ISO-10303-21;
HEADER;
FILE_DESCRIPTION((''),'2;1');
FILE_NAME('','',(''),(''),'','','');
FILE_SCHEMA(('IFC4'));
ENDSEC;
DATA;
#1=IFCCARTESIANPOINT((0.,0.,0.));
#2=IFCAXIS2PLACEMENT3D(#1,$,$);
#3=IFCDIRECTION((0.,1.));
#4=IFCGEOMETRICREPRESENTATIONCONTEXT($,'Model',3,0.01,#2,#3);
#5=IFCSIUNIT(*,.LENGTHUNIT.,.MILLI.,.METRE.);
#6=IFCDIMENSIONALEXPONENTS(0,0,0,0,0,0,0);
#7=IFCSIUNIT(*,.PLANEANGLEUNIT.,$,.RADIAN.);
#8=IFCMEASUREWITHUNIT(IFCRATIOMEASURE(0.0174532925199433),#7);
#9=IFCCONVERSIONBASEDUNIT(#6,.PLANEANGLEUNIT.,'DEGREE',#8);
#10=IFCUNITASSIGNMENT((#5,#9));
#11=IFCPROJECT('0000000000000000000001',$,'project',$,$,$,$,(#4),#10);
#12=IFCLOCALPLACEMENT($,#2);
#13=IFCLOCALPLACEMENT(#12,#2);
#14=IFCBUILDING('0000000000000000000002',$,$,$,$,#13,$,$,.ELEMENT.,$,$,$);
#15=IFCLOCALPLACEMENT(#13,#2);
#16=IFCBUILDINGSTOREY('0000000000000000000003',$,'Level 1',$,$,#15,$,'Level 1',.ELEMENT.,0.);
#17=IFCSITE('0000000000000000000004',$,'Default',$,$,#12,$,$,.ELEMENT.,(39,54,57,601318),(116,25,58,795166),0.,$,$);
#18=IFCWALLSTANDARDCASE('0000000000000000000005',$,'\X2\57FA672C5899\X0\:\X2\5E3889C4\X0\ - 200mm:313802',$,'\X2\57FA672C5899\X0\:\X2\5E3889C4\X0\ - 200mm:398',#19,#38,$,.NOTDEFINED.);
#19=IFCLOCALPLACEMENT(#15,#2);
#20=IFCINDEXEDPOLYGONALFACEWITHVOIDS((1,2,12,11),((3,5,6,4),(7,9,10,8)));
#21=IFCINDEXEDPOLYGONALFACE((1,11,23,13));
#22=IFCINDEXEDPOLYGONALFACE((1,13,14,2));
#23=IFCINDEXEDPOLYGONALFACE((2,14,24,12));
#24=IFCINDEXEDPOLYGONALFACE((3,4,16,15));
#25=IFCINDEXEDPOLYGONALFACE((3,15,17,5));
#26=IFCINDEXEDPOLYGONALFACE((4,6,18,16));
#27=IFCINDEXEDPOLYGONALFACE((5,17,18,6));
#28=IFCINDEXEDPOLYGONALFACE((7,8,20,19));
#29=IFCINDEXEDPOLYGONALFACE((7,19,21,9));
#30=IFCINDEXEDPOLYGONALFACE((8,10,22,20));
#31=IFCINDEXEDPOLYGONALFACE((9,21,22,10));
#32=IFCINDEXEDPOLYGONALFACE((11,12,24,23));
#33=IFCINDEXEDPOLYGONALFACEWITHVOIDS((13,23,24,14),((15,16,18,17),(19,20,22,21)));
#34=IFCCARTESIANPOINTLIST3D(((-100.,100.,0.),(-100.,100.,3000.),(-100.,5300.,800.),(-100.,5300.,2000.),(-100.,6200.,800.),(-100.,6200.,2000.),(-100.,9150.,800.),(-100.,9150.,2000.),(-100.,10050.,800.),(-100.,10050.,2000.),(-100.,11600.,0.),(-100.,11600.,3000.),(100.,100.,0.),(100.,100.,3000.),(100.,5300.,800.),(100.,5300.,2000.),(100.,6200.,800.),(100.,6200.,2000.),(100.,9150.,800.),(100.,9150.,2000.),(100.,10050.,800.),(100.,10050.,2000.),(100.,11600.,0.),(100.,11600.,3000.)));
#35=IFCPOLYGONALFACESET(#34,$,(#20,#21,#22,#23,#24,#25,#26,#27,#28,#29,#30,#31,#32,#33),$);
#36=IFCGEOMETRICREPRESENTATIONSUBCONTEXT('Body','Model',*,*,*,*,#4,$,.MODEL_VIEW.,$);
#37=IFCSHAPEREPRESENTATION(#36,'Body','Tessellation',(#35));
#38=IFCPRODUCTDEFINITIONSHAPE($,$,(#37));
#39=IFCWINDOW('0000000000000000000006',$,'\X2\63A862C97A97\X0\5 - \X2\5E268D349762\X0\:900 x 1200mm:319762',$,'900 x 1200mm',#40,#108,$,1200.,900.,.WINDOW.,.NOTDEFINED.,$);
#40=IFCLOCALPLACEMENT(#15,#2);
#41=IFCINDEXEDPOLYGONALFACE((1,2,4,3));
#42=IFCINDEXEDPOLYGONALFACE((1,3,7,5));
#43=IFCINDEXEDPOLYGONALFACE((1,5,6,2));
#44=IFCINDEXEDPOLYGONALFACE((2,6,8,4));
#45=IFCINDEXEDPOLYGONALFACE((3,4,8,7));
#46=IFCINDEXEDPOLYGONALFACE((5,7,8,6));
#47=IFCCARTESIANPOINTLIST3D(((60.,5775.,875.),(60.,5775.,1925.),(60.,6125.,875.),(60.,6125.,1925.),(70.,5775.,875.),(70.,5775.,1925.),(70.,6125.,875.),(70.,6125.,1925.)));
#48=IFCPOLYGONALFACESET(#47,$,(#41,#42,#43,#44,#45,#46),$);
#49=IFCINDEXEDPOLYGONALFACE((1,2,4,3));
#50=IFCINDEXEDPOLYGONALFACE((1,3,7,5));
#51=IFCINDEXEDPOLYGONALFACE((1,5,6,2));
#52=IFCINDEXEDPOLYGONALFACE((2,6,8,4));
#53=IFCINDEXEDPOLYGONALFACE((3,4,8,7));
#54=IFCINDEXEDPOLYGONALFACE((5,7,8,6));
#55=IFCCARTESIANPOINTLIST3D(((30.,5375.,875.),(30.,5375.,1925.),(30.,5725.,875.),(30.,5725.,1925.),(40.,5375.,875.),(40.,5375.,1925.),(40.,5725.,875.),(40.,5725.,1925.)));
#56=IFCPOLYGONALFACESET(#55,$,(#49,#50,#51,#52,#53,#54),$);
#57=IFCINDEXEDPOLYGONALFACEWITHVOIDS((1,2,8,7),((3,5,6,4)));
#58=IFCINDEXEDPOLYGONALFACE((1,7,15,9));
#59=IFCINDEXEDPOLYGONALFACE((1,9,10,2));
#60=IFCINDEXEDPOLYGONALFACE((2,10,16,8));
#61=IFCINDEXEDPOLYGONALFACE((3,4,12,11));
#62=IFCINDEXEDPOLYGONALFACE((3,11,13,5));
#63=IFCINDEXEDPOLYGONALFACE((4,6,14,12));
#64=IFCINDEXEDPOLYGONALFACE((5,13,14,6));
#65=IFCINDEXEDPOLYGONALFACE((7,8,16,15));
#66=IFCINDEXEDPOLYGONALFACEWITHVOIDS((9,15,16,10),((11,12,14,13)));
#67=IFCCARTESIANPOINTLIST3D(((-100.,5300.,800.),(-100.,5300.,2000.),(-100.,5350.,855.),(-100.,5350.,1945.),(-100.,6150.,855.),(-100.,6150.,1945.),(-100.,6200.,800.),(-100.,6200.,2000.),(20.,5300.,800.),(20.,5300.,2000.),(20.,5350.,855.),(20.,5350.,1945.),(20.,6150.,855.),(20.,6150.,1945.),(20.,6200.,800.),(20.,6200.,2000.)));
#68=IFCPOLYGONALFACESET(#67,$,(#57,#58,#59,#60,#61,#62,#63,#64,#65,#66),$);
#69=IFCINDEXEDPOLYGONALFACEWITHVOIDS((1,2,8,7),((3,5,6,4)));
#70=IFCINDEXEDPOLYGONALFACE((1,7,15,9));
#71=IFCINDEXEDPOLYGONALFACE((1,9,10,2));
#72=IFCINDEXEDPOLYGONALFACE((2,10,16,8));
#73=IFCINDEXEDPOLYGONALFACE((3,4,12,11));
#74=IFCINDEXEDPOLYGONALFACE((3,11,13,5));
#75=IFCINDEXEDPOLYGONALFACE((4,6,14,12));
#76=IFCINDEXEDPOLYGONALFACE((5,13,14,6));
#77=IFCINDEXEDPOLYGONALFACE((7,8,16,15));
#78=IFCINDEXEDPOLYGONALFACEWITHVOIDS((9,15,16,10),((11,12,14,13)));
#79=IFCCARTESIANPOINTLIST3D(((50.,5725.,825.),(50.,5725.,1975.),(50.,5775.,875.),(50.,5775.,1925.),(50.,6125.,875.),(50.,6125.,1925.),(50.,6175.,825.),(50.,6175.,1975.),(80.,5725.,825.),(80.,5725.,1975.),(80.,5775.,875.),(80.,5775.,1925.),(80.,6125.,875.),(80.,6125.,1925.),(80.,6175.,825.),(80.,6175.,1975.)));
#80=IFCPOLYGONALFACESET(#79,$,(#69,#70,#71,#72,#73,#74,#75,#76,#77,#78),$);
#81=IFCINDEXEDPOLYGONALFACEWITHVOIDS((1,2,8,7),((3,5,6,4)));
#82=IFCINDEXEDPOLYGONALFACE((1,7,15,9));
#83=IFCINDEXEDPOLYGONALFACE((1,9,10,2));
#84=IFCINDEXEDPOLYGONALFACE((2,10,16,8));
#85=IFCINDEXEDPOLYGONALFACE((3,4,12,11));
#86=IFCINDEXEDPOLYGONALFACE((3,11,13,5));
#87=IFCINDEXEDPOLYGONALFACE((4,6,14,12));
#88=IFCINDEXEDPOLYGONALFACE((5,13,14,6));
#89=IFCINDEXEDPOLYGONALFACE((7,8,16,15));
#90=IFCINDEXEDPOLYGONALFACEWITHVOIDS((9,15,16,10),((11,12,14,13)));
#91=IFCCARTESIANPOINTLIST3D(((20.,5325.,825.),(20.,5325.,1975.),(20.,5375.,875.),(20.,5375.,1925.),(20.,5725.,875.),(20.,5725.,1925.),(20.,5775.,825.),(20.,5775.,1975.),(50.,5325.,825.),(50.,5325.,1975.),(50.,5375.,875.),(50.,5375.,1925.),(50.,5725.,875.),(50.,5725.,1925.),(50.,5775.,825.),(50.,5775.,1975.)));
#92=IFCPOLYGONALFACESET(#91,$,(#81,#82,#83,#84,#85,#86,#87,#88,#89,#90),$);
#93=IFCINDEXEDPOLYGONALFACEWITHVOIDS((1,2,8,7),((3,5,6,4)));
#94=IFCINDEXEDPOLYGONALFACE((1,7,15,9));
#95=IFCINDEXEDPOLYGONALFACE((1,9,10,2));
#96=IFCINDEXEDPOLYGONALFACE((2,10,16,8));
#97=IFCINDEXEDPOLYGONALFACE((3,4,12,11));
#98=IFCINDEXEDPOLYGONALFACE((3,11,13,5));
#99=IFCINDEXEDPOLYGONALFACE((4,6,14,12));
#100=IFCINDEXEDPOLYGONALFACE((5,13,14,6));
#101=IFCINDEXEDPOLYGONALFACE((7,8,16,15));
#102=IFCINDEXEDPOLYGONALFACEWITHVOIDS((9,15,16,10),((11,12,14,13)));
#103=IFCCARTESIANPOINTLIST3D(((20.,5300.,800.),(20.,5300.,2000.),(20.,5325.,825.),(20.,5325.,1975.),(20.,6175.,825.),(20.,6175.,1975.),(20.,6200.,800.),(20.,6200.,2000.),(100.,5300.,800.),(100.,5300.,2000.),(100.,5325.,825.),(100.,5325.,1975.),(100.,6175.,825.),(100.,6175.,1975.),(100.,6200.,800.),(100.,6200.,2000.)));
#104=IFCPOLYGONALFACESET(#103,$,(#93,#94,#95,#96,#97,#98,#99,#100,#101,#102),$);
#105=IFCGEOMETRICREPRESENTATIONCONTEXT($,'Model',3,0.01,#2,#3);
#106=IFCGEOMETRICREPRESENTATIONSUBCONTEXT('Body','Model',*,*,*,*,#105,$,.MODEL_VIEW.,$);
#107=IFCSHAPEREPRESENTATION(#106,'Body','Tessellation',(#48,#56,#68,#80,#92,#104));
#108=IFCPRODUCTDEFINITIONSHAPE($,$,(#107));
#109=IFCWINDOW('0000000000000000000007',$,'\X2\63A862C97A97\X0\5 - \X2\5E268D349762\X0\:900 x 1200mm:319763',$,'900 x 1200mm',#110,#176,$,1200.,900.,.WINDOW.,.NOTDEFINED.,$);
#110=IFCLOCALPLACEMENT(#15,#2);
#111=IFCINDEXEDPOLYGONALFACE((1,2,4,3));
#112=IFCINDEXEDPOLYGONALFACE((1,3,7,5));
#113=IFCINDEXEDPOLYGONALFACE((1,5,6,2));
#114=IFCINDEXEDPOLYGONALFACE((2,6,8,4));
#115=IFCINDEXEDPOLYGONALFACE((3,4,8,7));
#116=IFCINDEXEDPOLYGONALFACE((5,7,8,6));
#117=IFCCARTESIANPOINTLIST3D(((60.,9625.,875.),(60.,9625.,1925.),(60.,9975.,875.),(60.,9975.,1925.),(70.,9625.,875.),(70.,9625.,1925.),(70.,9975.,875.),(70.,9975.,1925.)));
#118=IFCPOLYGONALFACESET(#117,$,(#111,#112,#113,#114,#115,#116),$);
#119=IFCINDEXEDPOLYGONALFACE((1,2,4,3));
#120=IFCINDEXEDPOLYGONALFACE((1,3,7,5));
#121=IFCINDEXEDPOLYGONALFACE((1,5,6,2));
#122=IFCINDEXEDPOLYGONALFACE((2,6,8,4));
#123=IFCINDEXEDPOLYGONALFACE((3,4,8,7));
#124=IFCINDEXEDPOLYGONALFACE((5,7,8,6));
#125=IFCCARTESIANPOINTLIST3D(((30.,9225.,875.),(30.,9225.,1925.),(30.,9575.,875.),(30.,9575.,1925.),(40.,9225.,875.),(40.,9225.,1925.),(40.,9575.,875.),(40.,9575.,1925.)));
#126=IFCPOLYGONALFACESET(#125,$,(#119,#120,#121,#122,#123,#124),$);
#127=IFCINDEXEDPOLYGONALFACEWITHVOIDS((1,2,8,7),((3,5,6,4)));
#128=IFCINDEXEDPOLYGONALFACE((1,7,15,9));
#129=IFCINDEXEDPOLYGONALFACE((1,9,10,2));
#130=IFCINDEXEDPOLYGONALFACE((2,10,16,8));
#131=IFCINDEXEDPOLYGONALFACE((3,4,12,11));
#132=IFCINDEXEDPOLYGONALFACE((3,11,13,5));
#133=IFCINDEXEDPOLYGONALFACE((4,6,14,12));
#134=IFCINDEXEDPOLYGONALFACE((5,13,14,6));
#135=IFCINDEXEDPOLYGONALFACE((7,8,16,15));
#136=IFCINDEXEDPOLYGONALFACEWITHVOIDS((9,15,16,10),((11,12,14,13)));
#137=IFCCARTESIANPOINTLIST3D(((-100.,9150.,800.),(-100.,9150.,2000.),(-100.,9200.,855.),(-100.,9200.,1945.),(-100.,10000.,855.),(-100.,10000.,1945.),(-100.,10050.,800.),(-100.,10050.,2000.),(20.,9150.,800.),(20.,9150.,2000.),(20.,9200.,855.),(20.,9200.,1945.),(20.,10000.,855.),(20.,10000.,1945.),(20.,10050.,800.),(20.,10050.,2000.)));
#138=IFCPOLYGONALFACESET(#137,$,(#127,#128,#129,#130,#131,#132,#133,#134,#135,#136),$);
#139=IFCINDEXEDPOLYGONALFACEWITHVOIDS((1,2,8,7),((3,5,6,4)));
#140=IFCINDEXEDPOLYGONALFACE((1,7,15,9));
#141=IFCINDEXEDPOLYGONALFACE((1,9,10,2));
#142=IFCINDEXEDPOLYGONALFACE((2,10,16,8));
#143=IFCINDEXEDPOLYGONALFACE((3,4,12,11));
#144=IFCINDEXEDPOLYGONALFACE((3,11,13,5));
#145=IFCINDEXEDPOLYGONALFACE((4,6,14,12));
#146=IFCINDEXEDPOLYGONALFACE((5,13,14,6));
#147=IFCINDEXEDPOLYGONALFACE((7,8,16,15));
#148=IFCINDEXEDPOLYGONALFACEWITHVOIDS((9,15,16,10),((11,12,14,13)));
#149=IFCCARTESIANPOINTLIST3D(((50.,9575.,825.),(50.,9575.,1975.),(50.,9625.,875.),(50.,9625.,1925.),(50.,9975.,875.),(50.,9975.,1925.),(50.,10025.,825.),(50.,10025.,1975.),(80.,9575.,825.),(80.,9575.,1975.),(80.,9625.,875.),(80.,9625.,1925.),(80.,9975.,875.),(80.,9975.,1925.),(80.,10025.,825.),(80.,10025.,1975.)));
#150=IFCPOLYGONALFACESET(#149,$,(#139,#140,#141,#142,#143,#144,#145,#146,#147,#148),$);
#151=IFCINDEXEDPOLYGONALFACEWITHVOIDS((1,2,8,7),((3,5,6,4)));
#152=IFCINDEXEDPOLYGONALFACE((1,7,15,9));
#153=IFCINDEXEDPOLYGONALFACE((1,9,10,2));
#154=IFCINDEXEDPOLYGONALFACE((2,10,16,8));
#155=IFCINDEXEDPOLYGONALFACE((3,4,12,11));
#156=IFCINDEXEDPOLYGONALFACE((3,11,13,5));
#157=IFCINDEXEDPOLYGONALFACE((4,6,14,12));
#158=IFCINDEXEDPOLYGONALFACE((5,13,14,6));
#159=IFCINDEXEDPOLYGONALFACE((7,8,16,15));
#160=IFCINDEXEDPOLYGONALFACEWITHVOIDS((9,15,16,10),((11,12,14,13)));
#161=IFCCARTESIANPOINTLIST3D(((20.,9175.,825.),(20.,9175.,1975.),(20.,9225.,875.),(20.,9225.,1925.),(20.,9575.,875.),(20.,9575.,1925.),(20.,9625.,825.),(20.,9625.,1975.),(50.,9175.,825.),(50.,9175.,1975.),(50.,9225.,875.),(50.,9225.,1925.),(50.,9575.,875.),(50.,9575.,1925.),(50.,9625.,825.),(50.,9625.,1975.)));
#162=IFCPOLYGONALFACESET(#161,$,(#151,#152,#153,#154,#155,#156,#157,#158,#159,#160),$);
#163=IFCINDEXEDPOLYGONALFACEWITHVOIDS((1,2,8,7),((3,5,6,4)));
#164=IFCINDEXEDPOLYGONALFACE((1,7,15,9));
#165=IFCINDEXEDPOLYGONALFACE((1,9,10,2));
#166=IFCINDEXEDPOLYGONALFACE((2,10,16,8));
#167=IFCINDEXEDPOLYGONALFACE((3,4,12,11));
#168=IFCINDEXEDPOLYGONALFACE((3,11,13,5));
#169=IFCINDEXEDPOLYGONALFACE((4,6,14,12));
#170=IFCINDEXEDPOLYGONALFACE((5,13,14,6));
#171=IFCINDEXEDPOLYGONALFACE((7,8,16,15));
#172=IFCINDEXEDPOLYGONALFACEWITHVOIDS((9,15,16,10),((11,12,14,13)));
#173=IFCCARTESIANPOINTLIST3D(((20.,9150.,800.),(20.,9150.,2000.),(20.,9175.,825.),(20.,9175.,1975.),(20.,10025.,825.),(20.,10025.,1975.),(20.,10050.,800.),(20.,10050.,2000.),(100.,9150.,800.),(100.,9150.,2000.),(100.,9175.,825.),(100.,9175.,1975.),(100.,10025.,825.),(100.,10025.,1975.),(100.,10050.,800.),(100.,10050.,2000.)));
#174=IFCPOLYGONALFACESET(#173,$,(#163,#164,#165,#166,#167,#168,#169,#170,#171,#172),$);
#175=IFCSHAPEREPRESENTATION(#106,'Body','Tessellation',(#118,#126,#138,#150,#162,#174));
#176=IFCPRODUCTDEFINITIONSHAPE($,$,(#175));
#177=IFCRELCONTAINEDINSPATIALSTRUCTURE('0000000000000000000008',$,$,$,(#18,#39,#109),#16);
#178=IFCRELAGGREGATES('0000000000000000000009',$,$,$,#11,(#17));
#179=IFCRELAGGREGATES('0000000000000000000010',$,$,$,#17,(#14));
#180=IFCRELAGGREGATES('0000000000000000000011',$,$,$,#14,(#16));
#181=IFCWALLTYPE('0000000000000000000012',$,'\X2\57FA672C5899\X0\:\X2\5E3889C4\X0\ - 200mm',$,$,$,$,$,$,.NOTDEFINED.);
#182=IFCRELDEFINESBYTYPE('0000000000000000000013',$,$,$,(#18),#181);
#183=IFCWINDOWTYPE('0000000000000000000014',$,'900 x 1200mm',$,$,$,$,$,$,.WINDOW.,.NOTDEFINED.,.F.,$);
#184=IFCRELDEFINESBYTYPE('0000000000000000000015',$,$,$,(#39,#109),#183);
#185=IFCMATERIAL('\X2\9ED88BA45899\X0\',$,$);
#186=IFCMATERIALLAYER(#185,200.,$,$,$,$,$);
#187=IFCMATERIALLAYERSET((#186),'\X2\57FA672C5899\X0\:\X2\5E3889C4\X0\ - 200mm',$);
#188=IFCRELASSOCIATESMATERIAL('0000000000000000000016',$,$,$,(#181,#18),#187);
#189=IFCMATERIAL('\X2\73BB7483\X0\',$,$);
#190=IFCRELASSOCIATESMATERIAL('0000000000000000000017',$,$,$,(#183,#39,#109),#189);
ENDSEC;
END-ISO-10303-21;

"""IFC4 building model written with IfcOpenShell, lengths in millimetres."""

from ifc_helpers import new_model, entity, si_unit, converted_unit, direction, frame, frame_2d, origin, origin_2d_with_axis, place, context, subcontext, project, spatial, polyline, rectangle, outline, extrude, source, transform, mapped, material, layer, layer_set, layer_usage, type_object, type_shapes, element, fill, save


model = new_model("IFC4")

# Units and contexts
model_context_1 = context("Model", 3, precision=0.01, world=origin(), true_north=direction((0.0, 1.0)))
model_context_2 = context("Model", 3, precision=0.01, world=origin(), true_north=direction((0.0, 1.0)))
body_context_1 = subcontext(model_context_1, "Body", "Model", "MODEL_VIEW")
body_context_2 = subcontext(model_context_2, "Body", "Model", "MODEL_VIEW")
ifc_project = project(units=[si_unit("LENGTHUNIT", "METRE", prefix="MILLI"), converted_unit("PLANEANGLEUNIT", "DEGREE", entity("IfcRatioMeasure", 0.0174532925199433), si_unit("PLANEANGLEUNIT", "RADIAN"), dimensions=[0, 0, 0, 0, 0, 0, 0])], contexts=[model_context_1])

# Site, building, storey
site_placement = place(None, origin())
site = spatial("IfcSite", under=ifc_project, at=site_placement, Name="Default", CompositionType="ELEMENT", RefLatitude=(39, 54, 57, 601318), RefLongitude=(116, 25, 58, 795166), RefElevation=0.0)
building_placement = place(site_placement, origin())
building = spatial("IfcBuilding", under=site, at=building_placement, CompositionType="ELEMENT")
storey_placement = place(building_placement, origin())
storey = spatial("IfcBuildingStorey", under=building, at=storey_placement, Name="Level 1", LongName="Level 1", CompositionType="ELEMENT", Elevation=0.0)

# Wall, openings, windows
ifc_material_1 = material(Name="默认墙")
ifc_layer_1 = layer(ifc_material_1, 200.0)
ifc_layer_set_1 = layer_set([ifc_layer_1], Name="基本墙:常规 - 200mm")
ifc_layer_usage_1 = layer_usage(ifc_layer_set_1, "AXIS2", "NEGATIVE", 100.0)
wall_type_1 = type_object("IfcWallType", Name="基本墙:常规 - 200mm", PredefinedType="NOTDEFINED", material=ifc_layer_set_1)
wall_1_placement = place(storey_placement, frame((0.0, 100.0, 0.0), z_axis=(0.0, 0.0, 1.0), x_axis=(0.0, 1.0, 0.0)))
wall_1 = element("IfcWallStandardCase", 1, at=wall_1_placement, inside=storey, type_object=wall_type_1, material=ifc_layer_usage_1, Name="基本墙:常规 - 200mm:313802", ObjectType="基本墙:常规 - 200mm:398", PredefinedType="NOTDEFINED", context=body_context_1, shape_type="SweptSolid", body=[
    extrude(rectangle(XDim=11500.0, YDim=200.0, at=frame_2d((5750.0, 0.0), x_axis=(-1.0, 0.0))), origin(), (0.0, 0.0, 1.0), 3000.0),
])
placement_1 = place(None, origin())
placement_2 = place(placement_1, origin())
placement_3 = place(placement_2, origin())
placement_4 = place(placement_3, frame((0.0, 100.0, 0.0), z_axis=(0.0, 0.0, 1.0), x_axis=(0.0, 1.0, 0.0)))
opening_1_placement = place(placement_4, frame((6100.0, 100.0, 800.0)))
opening_1 = element("IfcOpeningElement", 2, at=opening_1_placement, cuts=wall_1, ObjectType="Opening", PredefinedType="OPENING", context=body_context_2, shape_type="SweptSolid", body=[
    extrude(rectangle(XDim=1200.0, YDim=900.0, at=frame_2d((600.0, 450.0), x_axis=(-1.0, 0.0))), frame((0.0, 0.0, 0.0), z_axis=(0.0, -1.0, 0.0), x_axis=(0.0, 0.0, 1.0)), (0.0, 0.0, 1.0), 200.0),
])
opening_2_placement = place(placement_4, frame((9950.0, 100.0, 800.0)))
opening_2 = element("IfcOpeningElement", 3, at=opening_2_placement, cuts=wall_1, ObjectType="Opening", PredefinedType="OPENING", context=body_context_2, shape_type="SweptSolid", body=[
    extrude(rectangle(XDim=1200.0, YDim=900.0, at=frame_2d((600.0, 450.0), x_axis=(-1.0, 0.0))), frame((0.0, 0.0, 0.0), z_axis=(0.0, -1.0, 0.0), x_axis=(0.0, 0.0, 1.0)), (0.0, 0.0, 1.0), 200.0),
])
ifc_material_2 = material(Name="玻璃")
window_type_1 = type_object("IfcWindowType", Name="900 x 1200mm", ParameterTakesPrecedence=False, PartitioningType="NOTDEFINED", PredefinedType="WINDOW", material=ifc_material_2)
shared_shape_1 = source(origin(), body_context_2, "Body", "SweptSolid", [
    extrude(rectangle(XDim=10.0, YDim=350.0, at=origin_2d_with_axis()), frame((250.0, 165.0, 75.0), z_axis=(0.0, 0.0, 1.0), x_axis=(0.0, -1.0, 0.0)), (0.0, 0.0, 1.0), 1050.0),
    extrude(rectangle(XDim=10.0, YDim=350.0, at=origin_2d_with_axis()), frame((650.0, 135.0, 75.0), z_axis=(0.0, 0.0, 1.0), x_axis=(0.0, -1.0, 0.0)), (0.0, 0.0, 1.0), 1050.0),
    extrude(outline(polyline([(-450.0, -600.0), (450.0, -600.0), (450.0, 600.0), (-450.0, 600.0), (-450.0, -600.0)]), holes=[polyline([(400.0, -545.0), (-400.0, -545.0), (-400.0, 545.0), (400.0, 545.0), (400.0, -545.0)])]), frame((450.0, 0.0, 600.0), z_axis=(0.0, 1.0, 0.0), x_axis=(1.0, 0.0, 0.0)), (0.0, 0.0, 1.0), 120.0),
    extrude(outline(polyline([(-225.0, -575.0), (225.0, -575.0), (225.0, 575.0), (-225.0, 575.0), (-225.0, -575.0)]), holes=[polyline([(-175.0, -525.0), (-175.0, 525.0), (175.0, 525.0), (175.0, -525.0), (-175.0, -525.0)])]), frame((250.0, 150.0, 600.0), z_axis=(0.0, 1.0, 0.0), x_axis=(-1.0, 0.0, 0.0)), (0.0, 0.0, 1.0), 30.0),
    extrude(outline(polyline([(-225.0, -575.0), (225.0, -575.0), (225.0, 575.0), (-225.0, 575.0), (-225.0, -575.0)]), holes=[polyline([(-175.0, -525.0), (-175.0, 525.0), (175.0, 525.0), (175.0, -525.0), (-175.0, -525.0)])]), frame((650.0, 120.0, 600.0), z_axis=(0.0, 1.0, 0.0), x_axis=(1.0, 0.0, 0.0)), (0.0, 0.0, 1.0), 30.0),
    extrude(outline(polyline([(-450.0, -600.0), (450.0, -600.0), (450.0, 600.0), (-450.0, 600.0), (-450.0, -600.0)]), holes=[polyline([(-425.0, 575.0), (425.0, 575.0), (425.0, -575.0), (-425.0, -575.0), (-425.0, 575.0)])]), frame((450.0, 120.0, 600.0), z_axis=(0.0, 1.0, 0.0), x_axis=(1.0, 0.0, 0.0)), (0.0, 0.0, 1.0), 80.0),
])
type_shapes(window_type_1, [shared_shape_1])
window_1_placement = place(opening_1_placement, frame((0.0, 0.0, 0.0), z_axis=(0.0, 0.0, 1.0), x_axis=(-1.0, 0.0, 0.0)))
window_1 = element("IfcWindow", 4, at=window_1_placement, inside=storey, type_object=window_type_1, material=ifc_material_2, Name="推拉窗5 - 带贴面:900 x 1200mm:319762", ObjectType="900 x 1200mm", OverallHeight=1200.0, OverallWidth=900.0, PartitioningType="NOTDEFINED", PredefinedType="WINDOW", context=body_context_2, shape_type="MappedRepresentation", body=[
    mapped(shared_shape_1, transform((0.0, 0.0, 0.0), scale=1.0)),
])
fill(opening_1, window_1)
window_2_placement = place(opening_2_placement, frame((0.0, 0.0, 0.0), z_axis=(0.0, 0.0, 1.0), x_axis=(-1.0, 0.0, 0.0)))
window_2 = element("IfcWindow", 5, at=window_2_placement, inside=storey, type_object=window_type_1, material=ifc_material_2, Name="推拉窗5 - 带贴面:900 x 1200mm:319763", ObjectType="900 x 1200mm", OverallHeight=1200.0, OverallWidth=900.0, PartitioningType="NOTDEFINED", PredefinedType="WINDOW", context=body_context_2, shape_type="MappedRepresentation", body=[
    mapped(shared_shape_1, transform((0.0, 0.0, 0.0), scale=1.0)),
])
fill(opening_2, window_2)

save(model, "model.ifc")
